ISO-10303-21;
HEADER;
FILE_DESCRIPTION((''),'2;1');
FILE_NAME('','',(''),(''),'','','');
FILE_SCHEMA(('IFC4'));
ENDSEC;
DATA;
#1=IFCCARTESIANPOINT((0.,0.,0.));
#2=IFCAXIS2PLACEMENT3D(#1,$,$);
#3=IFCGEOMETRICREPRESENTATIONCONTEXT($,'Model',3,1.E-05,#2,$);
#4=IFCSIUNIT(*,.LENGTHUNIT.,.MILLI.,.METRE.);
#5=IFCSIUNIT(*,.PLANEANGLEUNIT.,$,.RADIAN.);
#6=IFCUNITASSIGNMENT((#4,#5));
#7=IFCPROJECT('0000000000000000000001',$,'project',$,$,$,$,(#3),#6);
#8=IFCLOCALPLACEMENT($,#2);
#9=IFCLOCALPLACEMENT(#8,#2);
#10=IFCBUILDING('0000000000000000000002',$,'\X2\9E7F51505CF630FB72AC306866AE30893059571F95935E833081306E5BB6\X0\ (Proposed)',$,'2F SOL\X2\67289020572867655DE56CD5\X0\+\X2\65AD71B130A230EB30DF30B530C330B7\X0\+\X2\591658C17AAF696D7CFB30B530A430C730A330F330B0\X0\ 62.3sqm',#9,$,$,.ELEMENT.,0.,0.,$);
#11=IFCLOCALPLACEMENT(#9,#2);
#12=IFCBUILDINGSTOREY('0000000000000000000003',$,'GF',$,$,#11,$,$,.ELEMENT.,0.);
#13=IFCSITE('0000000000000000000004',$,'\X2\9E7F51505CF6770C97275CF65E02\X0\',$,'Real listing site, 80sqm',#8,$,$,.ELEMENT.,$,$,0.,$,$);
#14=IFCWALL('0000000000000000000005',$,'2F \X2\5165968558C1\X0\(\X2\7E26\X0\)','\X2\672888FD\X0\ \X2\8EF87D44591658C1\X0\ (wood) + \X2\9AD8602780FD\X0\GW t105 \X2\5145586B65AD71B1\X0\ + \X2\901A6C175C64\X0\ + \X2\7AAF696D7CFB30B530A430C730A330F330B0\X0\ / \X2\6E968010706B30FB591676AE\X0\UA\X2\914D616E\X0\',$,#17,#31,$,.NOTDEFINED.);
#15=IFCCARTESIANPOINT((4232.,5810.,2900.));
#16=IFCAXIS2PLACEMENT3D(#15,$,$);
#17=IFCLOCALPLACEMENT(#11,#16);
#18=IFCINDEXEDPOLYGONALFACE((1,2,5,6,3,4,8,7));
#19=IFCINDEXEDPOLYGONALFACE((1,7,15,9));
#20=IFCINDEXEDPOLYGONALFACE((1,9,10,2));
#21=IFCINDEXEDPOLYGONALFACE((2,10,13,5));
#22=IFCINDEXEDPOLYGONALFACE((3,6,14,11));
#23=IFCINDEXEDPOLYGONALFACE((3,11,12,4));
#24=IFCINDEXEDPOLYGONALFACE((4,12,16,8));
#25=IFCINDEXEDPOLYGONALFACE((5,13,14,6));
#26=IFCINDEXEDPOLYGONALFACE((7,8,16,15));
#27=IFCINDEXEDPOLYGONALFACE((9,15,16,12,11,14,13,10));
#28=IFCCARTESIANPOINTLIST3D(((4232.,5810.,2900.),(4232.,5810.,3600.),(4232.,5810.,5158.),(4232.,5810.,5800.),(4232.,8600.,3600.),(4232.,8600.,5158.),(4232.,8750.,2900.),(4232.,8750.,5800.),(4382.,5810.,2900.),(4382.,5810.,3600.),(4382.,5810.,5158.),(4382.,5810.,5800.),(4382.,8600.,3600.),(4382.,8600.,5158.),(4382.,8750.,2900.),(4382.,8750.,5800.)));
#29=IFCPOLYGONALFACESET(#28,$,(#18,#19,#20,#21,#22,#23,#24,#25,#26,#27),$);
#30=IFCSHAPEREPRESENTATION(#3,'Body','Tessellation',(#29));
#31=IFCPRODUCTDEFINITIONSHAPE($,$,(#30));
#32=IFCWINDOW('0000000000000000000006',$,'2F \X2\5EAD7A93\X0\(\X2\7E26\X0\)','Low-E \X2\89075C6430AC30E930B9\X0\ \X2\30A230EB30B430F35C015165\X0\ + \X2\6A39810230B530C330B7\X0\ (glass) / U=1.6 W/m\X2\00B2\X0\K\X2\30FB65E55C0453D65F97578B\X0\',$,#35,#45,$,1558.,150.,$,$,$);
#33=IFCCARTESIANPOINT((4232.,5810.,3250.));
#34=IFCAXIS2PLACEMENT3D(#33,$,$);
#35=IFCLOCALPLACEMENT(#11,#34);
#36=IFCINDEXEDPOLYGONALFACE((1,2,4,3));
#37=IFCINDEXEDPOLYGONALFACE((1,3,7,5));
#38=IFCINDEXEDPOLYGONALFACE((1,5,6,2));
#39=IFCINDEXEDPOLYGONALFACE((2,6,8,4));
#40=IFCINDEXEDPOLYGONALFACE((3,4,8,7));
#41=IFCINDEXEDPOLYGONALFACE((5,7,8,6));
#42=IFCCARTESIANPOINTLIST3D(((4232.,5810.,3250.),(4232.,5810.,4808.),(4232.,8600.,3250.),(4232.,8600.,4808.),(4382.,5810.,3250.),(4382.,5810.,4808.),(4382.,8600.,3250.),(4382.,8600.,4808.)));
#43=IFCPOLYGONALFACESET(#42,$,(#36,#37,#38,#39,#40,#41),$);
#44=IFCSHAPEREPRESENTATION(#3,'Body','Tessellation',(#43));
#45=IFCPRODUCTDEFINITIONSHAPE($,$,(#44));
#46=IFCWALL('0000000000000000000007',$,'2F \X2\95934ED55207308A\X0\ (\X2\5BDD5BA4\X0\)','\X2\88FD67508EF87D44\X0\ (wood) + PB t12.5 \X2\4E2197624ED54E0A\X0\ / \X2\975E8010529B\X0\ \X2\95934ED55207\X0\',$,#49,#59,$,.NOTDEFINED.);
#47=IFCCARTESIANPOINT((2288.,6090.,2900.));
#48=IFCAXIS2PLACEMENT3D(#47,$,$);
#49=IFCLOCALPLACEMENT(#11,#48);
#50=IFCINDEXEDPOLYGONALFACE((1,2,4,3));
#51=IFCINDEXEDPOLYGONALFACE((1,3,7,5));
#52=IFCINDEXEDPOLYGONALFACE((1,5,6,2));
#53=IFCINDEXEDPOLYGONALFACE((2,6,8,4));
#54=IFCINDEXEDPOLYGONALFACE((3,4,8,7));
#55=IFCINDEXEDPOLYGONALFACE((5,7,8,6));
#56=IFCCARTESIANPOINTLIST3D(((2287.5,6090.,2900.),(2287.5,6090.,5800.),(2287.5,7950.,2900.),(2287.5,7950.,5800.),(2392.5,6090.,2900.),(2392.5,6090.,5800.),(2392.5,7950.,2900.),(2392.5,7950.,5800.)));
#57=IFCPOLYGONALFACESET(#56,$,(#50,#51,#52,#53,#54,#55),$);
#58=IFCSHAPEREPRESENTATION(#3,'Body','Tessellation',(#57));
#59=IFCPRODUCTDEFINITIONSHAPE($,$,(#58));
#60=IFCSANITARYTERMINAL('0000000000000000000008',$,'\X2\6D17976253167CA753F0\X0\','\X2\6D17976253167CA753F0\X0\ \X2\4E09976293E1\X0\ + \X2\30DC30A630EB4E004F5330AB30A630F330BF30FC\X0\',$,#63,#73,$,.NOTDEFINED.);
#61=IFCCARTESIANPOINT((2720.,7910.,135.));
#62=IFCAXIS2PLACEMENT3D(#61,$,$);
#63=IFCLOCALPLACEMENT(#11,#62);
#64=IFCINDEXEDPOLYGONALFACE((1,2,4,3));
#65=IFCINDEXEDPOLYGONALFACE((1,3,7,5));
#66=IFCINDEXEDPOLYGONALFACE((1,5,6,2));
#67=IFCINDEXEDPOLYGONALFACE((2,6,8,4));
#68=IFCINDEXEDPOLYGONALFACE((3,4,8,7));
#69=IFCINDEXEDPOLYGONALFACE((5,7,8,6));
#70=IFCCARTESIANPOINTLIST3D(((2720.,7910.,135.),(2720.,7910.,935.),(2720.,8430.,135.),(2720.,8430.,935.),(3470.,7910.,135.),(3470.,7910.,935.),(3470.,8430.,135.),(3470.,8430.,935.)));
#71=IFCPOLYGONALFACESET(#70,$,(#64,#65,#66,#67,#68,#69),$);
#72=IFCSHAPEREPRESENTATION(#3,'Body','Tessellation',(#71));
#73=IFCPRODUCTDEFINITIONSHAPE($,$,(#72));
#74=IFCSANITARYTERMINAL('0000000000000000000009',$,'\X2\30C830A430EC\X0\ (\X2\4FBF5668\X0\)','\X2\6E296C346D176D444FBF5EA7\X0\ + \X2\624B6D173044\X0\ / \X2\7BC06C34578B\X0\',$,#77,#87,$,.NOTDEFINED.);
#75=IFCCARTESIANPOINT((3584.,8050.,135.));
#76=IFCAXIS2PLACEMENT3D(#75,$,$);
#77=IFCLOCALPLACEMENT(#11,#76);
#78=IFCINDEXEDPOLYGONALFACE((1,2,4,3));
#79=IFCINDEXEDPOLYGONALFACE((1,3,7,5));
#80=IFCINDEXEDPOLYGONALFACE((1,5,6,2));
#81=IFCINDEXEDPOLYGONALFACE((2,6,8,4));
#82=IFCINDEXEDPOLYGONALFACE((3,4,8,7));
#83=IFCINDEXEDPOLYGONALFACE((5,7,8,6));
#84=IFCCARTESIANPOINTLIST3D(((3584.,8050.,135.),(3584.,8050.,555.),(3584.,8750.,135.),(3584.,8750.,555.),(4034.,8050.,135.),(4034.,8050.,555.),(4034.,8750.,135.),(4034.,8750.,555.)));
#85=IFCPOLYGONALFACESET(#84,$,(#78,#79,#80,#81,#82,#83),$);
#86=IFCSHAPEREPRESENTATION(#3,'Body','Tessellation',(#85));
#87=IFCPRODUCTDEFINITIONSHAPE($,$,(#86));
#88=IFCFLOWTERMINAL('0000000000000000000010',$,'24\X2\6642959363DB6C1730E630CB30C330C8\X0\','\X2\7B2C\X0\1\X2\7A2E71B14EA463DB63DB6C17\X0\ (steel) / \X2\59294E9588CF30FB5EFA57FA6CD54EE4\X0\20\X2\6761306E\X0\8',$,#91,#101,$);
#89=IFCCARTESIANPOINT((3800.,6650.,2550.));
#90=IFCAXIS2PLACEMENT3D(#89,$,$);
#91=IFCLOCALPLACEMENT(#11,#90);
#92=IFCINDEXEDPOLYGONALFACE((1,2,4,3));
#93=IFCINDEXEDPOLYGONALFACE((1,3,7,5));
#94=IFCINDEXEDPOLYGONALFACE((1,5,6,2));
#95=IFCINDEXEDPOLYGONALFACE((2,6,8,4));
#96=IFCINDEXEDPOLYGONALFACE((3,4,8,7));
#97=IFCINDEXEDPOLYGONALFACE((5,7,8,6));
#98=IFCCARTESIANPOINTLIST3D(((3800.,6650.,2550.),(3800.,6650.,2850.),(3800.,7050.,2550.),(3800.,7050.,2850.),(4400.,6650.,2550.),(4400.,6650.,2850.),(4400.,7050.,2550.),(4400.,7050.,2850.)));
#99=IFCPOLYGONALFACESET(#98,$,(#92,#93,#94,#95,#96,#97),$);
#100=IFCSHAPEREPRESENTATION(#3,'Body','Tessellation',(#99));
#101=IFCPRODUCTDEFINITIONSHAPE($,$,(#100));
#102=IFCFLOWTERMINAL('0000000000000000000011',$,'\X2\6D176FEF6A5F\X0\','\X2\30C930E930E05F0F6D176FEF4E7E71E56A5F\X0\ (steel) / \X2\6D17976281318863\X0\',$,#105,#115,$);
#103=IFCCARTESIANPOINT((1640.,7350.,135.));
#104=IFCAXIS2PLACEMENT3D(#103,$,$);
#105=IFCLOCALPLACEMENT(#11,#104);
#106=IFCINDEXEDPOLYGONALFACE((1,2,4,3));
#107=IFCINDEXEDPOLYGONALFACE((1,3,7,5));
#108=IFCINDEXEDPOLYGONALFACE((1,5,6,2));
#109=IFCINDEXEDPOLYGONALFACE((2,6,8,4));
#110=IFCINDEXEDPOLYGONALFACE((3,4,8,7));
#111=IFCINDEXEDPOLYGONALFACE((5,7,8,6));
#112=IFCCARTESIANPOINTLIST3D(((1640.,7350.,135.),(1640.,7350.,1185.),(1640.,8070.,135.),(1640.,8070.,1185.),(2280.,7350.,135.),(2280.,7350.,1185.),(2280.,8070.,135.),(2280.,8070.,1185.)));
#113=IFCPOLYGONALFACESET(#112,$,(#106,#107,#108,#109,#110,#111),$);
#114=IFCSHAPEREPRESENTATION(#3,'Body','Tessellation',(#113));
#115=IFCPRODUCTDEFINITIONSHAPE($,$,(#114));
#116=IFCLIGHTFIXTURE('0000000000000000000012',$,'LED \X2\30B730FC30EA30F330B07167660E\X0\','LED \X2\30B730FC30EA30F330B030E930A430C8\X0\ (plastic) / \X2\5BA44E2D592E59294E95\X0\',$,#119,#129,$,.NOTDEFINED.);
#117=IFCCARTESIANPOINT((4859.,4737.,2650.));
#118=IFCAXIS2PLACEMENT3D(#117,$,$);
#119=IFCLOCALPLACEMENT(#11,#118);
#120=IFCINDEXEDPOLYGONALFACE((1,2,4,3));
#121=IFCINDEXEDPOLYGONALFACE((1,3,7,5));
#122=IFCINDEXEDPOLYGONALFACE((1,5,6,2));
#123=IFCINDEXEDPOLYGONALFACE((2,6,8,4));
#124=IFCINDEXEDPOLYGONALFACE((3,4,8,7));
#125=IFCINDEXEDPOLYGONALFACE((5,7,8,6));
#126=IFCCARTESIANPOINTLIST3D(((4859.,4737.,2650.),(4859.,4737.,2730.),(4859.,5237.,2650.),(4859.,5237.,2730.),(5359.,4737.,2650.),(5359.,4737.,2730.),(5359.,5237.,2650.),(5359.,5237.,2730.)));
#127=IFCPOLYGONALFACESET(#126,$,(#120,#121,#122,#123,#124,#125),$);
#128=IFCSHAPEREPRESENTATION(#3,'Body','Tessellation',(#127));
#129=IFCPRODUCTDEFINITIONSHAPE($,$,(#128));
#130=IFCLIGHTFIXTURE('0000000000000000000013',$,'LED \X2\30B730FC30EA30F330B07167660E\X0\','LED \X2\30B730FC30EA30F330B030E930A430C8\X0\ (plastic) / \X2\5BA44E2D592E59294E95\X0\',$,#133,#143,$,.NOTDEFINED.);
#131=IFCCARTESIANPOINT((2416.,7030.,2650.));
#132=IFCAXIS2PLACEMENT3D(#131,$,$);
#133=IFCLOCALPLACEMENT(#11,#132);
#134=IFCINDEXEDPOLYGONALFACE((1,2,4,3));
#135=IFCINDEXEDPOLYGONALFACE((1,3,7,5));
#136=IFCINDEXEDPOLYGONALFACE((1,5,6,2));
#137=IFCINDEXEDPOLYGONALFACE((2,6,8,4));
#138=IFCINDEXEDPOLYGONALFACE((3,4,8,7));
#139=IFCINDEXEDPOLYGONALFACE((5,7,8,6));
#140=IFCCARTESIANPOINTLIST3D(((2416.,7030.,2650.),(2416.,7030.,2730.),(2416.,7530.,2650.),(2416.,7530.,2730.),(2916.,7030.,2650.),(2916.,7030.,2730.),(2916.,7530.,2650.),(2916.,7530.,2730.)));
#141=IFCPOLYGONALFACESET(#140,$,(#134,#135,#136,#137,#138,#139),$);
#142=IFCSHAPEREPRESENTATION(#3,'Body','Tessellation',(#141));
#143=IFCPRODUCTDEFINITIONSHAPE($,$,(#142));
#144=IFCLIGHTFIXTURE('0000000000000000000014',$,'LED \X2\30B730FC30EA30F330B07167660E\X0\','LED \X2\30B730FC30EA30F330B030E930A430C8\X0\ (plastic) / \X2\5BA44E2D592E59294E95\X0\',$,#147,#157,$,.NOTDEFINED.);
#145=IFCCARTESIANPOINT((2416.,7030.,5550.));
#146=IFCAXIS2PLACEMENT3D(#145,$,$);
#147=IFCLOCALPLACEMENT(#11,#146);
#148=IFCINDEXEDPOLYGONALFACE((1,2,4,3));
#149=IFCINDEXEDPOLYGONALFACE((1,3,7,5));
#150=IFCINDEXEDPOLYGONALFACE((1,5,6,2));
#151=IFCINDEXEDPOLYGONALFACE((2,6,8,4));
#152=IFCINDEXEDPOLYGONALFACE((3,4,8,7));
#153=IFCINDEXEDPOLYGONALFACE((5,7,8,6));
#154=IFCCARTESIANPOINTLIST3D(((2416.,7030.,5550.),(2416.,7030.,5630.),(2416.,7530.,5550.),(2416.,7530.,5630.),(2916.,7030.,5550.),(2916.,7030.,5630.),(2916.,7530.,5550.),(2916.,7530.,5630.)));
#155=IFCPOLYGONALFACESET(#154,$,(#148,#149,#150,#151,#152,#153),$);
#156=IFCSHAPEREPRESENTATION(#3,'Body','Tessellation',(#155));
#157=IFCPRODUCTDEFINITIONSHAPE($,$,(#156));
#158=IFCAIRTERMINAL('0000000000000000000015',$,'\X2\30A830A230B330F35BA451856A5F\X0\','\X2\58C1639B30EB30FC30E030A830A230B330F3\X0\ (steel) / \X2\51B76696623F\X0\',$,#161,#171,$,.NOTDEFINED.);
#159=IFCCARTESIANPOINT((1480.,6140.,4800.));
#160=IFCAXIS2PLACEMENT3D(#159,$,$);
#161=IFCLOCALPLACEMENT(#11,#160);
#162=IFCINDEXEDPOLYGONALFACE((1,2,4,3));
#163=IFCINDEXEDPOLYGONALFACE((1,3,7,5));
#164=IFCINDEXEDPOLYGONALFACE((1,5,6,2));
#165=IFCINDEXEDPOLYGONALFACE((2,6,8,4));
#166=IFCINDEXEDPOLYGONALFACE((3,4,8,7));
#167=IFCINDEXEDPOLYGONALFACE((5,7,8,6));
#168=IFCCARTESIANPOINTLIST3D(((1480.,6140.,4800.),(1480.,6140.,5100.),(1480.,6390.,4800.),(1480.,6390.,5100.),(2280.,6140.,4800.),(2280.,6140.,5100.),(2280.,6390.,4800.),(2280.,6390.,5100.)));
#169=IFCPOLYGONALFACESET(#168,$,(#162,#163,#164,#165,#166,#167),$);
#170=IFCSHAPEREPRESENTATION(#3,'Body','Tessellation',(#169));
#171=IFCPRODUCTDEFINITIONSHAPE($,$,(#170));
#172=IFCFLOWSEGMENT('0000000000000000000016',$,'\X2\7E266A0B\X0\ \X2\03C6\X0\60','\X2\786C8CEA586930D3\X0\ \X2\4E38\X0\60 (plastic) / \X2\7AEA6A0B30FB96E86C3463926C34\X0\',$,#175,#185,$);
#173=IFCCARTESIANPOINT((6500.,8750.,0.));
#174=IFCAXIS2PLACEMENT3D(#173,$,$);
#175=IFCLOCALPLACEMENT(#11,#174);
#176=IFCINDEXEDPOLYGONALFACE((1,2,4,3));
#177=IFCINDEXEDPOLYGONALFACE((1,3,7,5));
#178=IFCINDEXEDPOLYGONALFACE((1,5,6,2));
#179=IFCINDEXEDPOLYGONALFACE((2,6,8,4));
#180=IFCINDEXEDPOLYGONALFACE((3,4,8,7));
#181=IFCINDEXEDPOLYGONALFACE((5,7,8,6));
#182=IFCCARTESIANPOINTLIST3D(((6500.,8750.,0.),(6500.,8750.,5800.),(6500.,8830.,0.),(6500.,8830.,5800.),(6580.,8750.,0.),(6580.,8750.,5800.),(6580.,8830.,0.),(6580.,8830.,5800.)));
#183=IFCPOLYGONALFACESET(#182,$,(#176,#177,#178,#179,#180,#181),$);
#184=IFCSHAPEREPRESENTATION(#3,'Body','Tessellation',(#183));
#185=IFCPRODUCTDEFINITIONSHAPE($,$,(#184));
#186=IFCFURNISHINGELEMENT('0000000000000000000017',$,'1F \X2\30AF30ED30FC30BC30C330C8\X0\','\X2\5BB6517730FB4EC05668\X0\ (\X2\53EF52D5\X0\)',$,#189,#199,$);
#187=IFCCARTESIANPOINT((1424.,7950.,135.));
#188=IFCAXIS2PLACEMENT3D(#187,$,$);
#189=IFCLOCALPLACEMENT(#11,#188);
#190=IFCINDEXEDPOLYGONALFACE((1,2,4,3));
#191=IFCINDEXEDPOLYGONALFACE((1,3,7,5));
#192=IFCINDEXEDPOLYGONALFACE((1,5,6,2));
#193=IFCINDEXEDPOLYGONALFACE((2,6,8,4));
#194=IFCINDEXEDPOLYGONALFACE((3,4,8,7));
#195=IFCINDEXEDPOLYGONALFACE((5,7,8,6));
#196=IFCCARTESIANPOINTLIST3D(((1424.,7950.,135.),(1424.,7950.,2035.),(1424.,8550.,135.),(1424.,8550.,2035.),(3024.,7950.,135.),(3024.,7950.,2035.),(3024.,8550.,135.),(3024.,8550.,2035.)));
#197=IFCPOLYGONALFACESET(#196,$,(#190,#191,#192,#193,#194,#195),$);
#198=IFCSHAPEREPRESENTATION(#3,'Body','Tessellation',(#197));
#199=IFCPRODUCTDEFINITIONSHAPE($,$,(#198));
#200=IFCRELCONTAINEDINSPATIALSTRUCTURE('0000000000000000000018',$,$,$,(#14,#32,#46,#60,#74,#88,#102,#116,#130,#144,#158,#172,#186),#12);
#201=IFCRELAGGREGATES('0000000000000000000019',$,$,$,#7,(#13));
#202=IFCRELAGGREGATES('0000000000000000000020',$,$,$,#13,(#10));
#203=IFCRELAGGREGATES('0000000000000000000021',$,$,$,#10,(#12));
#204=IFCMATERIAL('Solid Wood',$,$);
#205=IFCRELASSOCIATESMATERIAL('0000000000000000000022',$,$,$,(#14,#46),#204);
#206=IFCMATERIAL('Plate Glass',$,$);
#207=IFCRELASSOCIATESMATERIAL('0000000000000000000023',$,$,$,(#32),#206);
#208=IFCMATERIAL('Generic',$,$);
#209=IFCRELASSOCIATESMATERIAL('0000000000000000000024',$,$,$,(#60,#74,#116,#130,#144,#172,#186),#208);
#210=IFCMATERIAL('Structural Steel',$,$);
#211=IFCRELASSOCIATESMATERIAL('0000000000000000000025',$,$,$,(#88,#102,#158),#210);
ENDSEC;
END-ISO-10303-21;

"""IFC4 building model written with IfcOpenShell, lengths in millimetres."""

from ifc_helpers import new_model, si_unit, frame, frame_2d, origin, place, context, project, spatial, rectangle, extrude, material, element, fill, save


model = new_model("IFC4")

# Units and contexts
model_context = context("Model", 3, precision=1e-05, world=origin())
ifc_project = project(units=[si_unit("LENGTHUNIT", "METRE", prefix="MILLI"), si_unit("PLANEANGLEUNIT", "RADIAN")], contexts=[model_context])

# Site, building, storey
site_placement = place(None, origin())
site = spatial("IfcSite", under=ifc_project, at=site_placement, Name="鹿児島県霧島市", ObjectType="Real listing site, 80sqm", CompositionType="ELEMENT", RefElevation=0.0)
building_placement = place(site_placement, origin())
building = spatial("IfcBuilding", under=site, at=building_placement, Name="鹿児島・犬と暮らす土間広めの家 (Proposed)", ObjectType="2F SOL木造在来工法+断熱アルミサッシ+外壁窯業系サイディング 62.3sqm", CompositionType="ELEMENT", ElevationOfRefHeight=0.0, ElevationOfTerrain=0.0)
storey_placement = place(building_placement, origin())
storey = spatial("IfcBuildingStorey", under=building, at=storey_placement, Name="GF", CompositionType="ELEMENT", Elevation=0.0)

# Shared definitions
ifc_material_1 = material(Name="Solid Wood")

# Shared definitions
ifc_material_2 = material(Name="Plate Glass")

# Wall, opening, window
wall_1_placement = place(storey_placement, frame((4232.0, 5810.0, 2900.0)))
wall_1 = element("IfcWall", 1, at=wall_1_placement, inside=storey, material=ifc_material_1, Name="2F 入隅壁(縦)", Description="木製 軸組外壁 (wood) + 高性能GW t105 充填断熱 + 通気層 + 窯業系サイディング / 準耐火・外皮UA配慮", PredefinedType="NOTDEFINED", context=model_context, shape_type="SweptSolid", body=[
    extrude(rectangle(XDim=150.0, YDim=2940.0, at=frame_2d((75.0, 1470.0))), frame((4232.0, 5810.0, 2900.0)), (0.0, 0.0, 1.0), 2900.0),
])
opening_1_placement = place(storey_placement, frame((4232.0, 5810.0, 3250.0)))
opening_1 = element("IfcOpeningElement", 2, at=opening_1_placement, cuts=wall_1, PredefinedType="NOTDEFINED", context=model_context, shape_type="SweptSolid", body=[
    extrude(rectangle(XDim=150.0, YDim=2790.0, at=frame_2d((75.0, 1395.0))), frame((4232.0, 5810.0, 3250.0)), (0.0, 0.0, 1.0), 1558.0),
])
window_1_placement = place(storey_placement, frame((4232.0, 5810.0, 3250.0)))
window_1 = element("IfcWindow", 3, at=window_1_placement, inside=storey, material=ifc_material_2, Name="2F 庭窓(縦)", Description="Low-E 複層ガラス アルゴン封入 + 樹脂サッシ (glass) / U=1.6 W/m²K・日射取得型", OverallHeight=1558.0, OverallWidth=150.0, context=model_context, shape_type="SweptSolid", body=[
    extrude(rectangle(XDim=150.0, YDim=2790.0, at=frame_2d((75.0, 1395.0))), frame((4232.0, 5810.0, 3250.0)), (0.0, 0.0, 1.0), 1558.0),
])
fill(opening_1, window_1)

# Wall
wall_2_placement = place(storey_placement, frame((2288.0, 6090.0, 2900.0)))
element("IfcWall", 4, at=wall_2_placement, inside=storey, material=ifc_material_1, Name="2F 間仕切り (寝室)", Description="製材軸組 (wood) + PB t12.5 両面仕上 / 非耐力 間仕切", PredefinedType="NOTDEFINED", context=model_context, shape_type="SweptSolid", body=[
    extrude(rectangle(XDim=105.0, YDim=1860.0, at=frame_2d((52.0, 930.0))), frame((2288.0, 6090.0, 2900.0)), (0.0, 0.0, 1.0), 2900.0),
])

# Sanitary terminals
ifc_material_3 = material(Name="Generic")
sanitary_terminal_1_placement = place(storey_placement, frame((2720.0, 7910.0, 135.0)))
element("IfcSanitaryTerminal", 5, at=sanitary_terminal_1_placement, inside=storey, material=ifc_material_3, Name="洗面化粧台", Description="洗面化粧台 三面鏡 + ボウル一体カウンター", PredefinedType="NOTDEFINED", context=model_context, shape_type="SweptSolid", body=[
    extrude(rectangle(XDim=750.0, YDim=520.0, at=frame_2d((375.0, 260.0))), frame((2720.0, 7910.0, 135.0)), (0.0, 0.0, 1.0), 800.0),
])
sanitary_terminal_2_placement = place(storey_placement, frame((3584.0, 8050.0, 135.0)))
element("IfcSanitaryTerminal", 6, at=sanitary_terminal_2_placement, inside=storey, material=ifc_material_3, Name="トイレ (便器)", Description="温水洗浄便座 + 手洗い / 節水型", PredefinedType="NOTDEFINED", context=model_context, shape_type="SweptSolid", body=[
    extrude(rectangle(XDim=450.0, YDim=700.0, at=frame_2d((225.0, 350.0))), frame((3584.0, 8050.0, 135.0)), (0.0, 0.0, 1.0), 420.0),
])

# Flow terminals
ifc_material_4 = material(Name="Structural Steel")
flow_terminal_1_placement = place(storey_placement, frame((3800.0, 6650.0, 2550.0)))
element("IfcFlowTerminal", 7, at=flow_terminal_1_placement, inside=storey, material=ifc_material_4, Name="24時間換気ユニット", Description="第1種熱交換換気 (steel) / 天井裏・建基法令20条の8", context=model_context, shape_type="SweptSolid", body=[
    extrude(rectangle(XDim=600.0, YDim=400.0, at=frame_2d((300.0, 200.0))), frame((3800.0, 6650.0, 2550.0)), (0.0, 0.0, 1.0), 300.0),
])
flow_terminal_2_placement = place(storey_placement, frame((1640.0, 7350.0, 135.0)))
element("IfcFlowTerminal", 8, at=flow_terminal_2_placement, inside=storey, material=ifc_material_4, Name="洗濯機", Description="ドラム式洗濯乾燥機 (steel) / 洗面脱衣", context=model_context, shape_type="SweptSolid", body=[
    extrude(rectangle(XDim=640.0, YDim=720.0, at=frame_2d((320.0, 360.0))), frame((1640.0, 7350.0, 135.0)), (0.0, 0.0, 1.0), 1050.0),
])

# Light fixtures
light_fixture_1_placement = place(storey_placement, frame((4859.0, 4737.0, 2650.0)))
element("IfcLightFixture", 9, at=light_fixture_1_placement, inside=storey, material=ifc_material_3, Name="LED シーリング照明", Description="LED シーリングライト (plastic) / 室中央天井", PredefinedType="NOTDEFINED", context=model_context, shape_type="SweptSolid", body=[
    extrude(rectangle(XDim=500.0, YDim=500.0, at=frame_2d((250.0, 250.0))), frame((4859.0, 4737.0, 2650.0)), (0.0, 0.0, 1.0), 80.0),
])
light_fixture_2_placement = place(storey_placement, frame((2416.0, 7030.0, 2650.0)))
element("IfcLightFixture", 10, at=light_fixture_2_placement, inside=storey, material=ifc_material_3, Name="LED シーリング照明", Description="LED シーリングライト (plastic) / 室中央天井", PredefinedType="NOTDEFINED", context=model_context, shape_type="SweptSolid", body=[
    extrude(rectangle(XDim=500.0, YDim=500.0, at=frame_2d((250.0, 250.0))), frame((2416.0, 7030.0, 2650.0)), (0.0, 0.0, 1.0), 80.0),
])
light_fixture_3_placement = place(storey_placement, frame((2416.0, 7030.0, 5550.0)))
element("IfcLightFixture", 11, at=light_fixture_3_placement, inside=storey, material=ifc_material_3, Name="LED シーリング照明", Description="LED シーリングライト (plastic) / 室中央天井", PredefinedType="NOTDEFINED", context=model_context, shape_type="SweptSolid", body=[
    extrude(rectangle(XDim=500.0, YDim=500.0, at=frame_2d((250.0, 250.0))), frame((2416.0, 7030.0, 5550.0)), (0.0, 0.0, 1.0), 80.0),
])

# Air terminal
air_terminal_placement = place(storey_placement, frame((1480.0, 6140.0, 4800.0)))
element("IfcAirTerminal", 12, at=air_terminal_placement, inside=storey, material=ifc_material_4, Name="エアコン室内機", Description="壁掛ルームエアコン (steel) / 冷暖房", PredefinedType="NOTDEFINED", context=model_context, shape_type="SweptSolid", body=[
    extrude(rectangle(XDim=800.0, YDim=250.0, at=frame_2d((400.0, 125.0))), frame((1480.0, 6140.0, 4800.0)), (0.0, 0.0, 1.0), 300.0),
])

# Flow segment
flow_segment_placement = place(storey_placement, frame((6500.0, 8750.0, 0.0)))
element("IfcFlowSegment", 13, at=flow_segment_placement, inside=storey, material=ifc_material_3, Name="縦樋 φ60", Description="硬質塩ビ 丸60 (plastic) / 竪樋・雨水排水", context=model_context, shape_type="SweptSolid", body=[
    extrude(rectangle(XDim=80.0, YDim=80.0, at=frame_2d((40.0, 40.0))), frame((6500.0, 8750.0, 0.0)), (0.0, 0.0, 1.0), 5800.0),
])

# Furnishing element
furnishing_1_placement = place(storey_placement, frame((1424.0, 7950.0, 135.0)))
element("IfcFurnishingElement", 14, at=furnishing_1_placement, inside=storey, material=ifc_material_3, Name="1F クローゼット", Description="家具・什器 (可動)", context=model_context, shape_type="SweptSolid", body=[
    extrude(rectangle(XDim=1600.0, YDim=600.0, at=frame_2d((800.0, 300.0))), frame((1424.0, 7950.0, 135.0)), (0.0, 0.0, 1.0), 1900.0),
])

save(model, "model.ifc")
